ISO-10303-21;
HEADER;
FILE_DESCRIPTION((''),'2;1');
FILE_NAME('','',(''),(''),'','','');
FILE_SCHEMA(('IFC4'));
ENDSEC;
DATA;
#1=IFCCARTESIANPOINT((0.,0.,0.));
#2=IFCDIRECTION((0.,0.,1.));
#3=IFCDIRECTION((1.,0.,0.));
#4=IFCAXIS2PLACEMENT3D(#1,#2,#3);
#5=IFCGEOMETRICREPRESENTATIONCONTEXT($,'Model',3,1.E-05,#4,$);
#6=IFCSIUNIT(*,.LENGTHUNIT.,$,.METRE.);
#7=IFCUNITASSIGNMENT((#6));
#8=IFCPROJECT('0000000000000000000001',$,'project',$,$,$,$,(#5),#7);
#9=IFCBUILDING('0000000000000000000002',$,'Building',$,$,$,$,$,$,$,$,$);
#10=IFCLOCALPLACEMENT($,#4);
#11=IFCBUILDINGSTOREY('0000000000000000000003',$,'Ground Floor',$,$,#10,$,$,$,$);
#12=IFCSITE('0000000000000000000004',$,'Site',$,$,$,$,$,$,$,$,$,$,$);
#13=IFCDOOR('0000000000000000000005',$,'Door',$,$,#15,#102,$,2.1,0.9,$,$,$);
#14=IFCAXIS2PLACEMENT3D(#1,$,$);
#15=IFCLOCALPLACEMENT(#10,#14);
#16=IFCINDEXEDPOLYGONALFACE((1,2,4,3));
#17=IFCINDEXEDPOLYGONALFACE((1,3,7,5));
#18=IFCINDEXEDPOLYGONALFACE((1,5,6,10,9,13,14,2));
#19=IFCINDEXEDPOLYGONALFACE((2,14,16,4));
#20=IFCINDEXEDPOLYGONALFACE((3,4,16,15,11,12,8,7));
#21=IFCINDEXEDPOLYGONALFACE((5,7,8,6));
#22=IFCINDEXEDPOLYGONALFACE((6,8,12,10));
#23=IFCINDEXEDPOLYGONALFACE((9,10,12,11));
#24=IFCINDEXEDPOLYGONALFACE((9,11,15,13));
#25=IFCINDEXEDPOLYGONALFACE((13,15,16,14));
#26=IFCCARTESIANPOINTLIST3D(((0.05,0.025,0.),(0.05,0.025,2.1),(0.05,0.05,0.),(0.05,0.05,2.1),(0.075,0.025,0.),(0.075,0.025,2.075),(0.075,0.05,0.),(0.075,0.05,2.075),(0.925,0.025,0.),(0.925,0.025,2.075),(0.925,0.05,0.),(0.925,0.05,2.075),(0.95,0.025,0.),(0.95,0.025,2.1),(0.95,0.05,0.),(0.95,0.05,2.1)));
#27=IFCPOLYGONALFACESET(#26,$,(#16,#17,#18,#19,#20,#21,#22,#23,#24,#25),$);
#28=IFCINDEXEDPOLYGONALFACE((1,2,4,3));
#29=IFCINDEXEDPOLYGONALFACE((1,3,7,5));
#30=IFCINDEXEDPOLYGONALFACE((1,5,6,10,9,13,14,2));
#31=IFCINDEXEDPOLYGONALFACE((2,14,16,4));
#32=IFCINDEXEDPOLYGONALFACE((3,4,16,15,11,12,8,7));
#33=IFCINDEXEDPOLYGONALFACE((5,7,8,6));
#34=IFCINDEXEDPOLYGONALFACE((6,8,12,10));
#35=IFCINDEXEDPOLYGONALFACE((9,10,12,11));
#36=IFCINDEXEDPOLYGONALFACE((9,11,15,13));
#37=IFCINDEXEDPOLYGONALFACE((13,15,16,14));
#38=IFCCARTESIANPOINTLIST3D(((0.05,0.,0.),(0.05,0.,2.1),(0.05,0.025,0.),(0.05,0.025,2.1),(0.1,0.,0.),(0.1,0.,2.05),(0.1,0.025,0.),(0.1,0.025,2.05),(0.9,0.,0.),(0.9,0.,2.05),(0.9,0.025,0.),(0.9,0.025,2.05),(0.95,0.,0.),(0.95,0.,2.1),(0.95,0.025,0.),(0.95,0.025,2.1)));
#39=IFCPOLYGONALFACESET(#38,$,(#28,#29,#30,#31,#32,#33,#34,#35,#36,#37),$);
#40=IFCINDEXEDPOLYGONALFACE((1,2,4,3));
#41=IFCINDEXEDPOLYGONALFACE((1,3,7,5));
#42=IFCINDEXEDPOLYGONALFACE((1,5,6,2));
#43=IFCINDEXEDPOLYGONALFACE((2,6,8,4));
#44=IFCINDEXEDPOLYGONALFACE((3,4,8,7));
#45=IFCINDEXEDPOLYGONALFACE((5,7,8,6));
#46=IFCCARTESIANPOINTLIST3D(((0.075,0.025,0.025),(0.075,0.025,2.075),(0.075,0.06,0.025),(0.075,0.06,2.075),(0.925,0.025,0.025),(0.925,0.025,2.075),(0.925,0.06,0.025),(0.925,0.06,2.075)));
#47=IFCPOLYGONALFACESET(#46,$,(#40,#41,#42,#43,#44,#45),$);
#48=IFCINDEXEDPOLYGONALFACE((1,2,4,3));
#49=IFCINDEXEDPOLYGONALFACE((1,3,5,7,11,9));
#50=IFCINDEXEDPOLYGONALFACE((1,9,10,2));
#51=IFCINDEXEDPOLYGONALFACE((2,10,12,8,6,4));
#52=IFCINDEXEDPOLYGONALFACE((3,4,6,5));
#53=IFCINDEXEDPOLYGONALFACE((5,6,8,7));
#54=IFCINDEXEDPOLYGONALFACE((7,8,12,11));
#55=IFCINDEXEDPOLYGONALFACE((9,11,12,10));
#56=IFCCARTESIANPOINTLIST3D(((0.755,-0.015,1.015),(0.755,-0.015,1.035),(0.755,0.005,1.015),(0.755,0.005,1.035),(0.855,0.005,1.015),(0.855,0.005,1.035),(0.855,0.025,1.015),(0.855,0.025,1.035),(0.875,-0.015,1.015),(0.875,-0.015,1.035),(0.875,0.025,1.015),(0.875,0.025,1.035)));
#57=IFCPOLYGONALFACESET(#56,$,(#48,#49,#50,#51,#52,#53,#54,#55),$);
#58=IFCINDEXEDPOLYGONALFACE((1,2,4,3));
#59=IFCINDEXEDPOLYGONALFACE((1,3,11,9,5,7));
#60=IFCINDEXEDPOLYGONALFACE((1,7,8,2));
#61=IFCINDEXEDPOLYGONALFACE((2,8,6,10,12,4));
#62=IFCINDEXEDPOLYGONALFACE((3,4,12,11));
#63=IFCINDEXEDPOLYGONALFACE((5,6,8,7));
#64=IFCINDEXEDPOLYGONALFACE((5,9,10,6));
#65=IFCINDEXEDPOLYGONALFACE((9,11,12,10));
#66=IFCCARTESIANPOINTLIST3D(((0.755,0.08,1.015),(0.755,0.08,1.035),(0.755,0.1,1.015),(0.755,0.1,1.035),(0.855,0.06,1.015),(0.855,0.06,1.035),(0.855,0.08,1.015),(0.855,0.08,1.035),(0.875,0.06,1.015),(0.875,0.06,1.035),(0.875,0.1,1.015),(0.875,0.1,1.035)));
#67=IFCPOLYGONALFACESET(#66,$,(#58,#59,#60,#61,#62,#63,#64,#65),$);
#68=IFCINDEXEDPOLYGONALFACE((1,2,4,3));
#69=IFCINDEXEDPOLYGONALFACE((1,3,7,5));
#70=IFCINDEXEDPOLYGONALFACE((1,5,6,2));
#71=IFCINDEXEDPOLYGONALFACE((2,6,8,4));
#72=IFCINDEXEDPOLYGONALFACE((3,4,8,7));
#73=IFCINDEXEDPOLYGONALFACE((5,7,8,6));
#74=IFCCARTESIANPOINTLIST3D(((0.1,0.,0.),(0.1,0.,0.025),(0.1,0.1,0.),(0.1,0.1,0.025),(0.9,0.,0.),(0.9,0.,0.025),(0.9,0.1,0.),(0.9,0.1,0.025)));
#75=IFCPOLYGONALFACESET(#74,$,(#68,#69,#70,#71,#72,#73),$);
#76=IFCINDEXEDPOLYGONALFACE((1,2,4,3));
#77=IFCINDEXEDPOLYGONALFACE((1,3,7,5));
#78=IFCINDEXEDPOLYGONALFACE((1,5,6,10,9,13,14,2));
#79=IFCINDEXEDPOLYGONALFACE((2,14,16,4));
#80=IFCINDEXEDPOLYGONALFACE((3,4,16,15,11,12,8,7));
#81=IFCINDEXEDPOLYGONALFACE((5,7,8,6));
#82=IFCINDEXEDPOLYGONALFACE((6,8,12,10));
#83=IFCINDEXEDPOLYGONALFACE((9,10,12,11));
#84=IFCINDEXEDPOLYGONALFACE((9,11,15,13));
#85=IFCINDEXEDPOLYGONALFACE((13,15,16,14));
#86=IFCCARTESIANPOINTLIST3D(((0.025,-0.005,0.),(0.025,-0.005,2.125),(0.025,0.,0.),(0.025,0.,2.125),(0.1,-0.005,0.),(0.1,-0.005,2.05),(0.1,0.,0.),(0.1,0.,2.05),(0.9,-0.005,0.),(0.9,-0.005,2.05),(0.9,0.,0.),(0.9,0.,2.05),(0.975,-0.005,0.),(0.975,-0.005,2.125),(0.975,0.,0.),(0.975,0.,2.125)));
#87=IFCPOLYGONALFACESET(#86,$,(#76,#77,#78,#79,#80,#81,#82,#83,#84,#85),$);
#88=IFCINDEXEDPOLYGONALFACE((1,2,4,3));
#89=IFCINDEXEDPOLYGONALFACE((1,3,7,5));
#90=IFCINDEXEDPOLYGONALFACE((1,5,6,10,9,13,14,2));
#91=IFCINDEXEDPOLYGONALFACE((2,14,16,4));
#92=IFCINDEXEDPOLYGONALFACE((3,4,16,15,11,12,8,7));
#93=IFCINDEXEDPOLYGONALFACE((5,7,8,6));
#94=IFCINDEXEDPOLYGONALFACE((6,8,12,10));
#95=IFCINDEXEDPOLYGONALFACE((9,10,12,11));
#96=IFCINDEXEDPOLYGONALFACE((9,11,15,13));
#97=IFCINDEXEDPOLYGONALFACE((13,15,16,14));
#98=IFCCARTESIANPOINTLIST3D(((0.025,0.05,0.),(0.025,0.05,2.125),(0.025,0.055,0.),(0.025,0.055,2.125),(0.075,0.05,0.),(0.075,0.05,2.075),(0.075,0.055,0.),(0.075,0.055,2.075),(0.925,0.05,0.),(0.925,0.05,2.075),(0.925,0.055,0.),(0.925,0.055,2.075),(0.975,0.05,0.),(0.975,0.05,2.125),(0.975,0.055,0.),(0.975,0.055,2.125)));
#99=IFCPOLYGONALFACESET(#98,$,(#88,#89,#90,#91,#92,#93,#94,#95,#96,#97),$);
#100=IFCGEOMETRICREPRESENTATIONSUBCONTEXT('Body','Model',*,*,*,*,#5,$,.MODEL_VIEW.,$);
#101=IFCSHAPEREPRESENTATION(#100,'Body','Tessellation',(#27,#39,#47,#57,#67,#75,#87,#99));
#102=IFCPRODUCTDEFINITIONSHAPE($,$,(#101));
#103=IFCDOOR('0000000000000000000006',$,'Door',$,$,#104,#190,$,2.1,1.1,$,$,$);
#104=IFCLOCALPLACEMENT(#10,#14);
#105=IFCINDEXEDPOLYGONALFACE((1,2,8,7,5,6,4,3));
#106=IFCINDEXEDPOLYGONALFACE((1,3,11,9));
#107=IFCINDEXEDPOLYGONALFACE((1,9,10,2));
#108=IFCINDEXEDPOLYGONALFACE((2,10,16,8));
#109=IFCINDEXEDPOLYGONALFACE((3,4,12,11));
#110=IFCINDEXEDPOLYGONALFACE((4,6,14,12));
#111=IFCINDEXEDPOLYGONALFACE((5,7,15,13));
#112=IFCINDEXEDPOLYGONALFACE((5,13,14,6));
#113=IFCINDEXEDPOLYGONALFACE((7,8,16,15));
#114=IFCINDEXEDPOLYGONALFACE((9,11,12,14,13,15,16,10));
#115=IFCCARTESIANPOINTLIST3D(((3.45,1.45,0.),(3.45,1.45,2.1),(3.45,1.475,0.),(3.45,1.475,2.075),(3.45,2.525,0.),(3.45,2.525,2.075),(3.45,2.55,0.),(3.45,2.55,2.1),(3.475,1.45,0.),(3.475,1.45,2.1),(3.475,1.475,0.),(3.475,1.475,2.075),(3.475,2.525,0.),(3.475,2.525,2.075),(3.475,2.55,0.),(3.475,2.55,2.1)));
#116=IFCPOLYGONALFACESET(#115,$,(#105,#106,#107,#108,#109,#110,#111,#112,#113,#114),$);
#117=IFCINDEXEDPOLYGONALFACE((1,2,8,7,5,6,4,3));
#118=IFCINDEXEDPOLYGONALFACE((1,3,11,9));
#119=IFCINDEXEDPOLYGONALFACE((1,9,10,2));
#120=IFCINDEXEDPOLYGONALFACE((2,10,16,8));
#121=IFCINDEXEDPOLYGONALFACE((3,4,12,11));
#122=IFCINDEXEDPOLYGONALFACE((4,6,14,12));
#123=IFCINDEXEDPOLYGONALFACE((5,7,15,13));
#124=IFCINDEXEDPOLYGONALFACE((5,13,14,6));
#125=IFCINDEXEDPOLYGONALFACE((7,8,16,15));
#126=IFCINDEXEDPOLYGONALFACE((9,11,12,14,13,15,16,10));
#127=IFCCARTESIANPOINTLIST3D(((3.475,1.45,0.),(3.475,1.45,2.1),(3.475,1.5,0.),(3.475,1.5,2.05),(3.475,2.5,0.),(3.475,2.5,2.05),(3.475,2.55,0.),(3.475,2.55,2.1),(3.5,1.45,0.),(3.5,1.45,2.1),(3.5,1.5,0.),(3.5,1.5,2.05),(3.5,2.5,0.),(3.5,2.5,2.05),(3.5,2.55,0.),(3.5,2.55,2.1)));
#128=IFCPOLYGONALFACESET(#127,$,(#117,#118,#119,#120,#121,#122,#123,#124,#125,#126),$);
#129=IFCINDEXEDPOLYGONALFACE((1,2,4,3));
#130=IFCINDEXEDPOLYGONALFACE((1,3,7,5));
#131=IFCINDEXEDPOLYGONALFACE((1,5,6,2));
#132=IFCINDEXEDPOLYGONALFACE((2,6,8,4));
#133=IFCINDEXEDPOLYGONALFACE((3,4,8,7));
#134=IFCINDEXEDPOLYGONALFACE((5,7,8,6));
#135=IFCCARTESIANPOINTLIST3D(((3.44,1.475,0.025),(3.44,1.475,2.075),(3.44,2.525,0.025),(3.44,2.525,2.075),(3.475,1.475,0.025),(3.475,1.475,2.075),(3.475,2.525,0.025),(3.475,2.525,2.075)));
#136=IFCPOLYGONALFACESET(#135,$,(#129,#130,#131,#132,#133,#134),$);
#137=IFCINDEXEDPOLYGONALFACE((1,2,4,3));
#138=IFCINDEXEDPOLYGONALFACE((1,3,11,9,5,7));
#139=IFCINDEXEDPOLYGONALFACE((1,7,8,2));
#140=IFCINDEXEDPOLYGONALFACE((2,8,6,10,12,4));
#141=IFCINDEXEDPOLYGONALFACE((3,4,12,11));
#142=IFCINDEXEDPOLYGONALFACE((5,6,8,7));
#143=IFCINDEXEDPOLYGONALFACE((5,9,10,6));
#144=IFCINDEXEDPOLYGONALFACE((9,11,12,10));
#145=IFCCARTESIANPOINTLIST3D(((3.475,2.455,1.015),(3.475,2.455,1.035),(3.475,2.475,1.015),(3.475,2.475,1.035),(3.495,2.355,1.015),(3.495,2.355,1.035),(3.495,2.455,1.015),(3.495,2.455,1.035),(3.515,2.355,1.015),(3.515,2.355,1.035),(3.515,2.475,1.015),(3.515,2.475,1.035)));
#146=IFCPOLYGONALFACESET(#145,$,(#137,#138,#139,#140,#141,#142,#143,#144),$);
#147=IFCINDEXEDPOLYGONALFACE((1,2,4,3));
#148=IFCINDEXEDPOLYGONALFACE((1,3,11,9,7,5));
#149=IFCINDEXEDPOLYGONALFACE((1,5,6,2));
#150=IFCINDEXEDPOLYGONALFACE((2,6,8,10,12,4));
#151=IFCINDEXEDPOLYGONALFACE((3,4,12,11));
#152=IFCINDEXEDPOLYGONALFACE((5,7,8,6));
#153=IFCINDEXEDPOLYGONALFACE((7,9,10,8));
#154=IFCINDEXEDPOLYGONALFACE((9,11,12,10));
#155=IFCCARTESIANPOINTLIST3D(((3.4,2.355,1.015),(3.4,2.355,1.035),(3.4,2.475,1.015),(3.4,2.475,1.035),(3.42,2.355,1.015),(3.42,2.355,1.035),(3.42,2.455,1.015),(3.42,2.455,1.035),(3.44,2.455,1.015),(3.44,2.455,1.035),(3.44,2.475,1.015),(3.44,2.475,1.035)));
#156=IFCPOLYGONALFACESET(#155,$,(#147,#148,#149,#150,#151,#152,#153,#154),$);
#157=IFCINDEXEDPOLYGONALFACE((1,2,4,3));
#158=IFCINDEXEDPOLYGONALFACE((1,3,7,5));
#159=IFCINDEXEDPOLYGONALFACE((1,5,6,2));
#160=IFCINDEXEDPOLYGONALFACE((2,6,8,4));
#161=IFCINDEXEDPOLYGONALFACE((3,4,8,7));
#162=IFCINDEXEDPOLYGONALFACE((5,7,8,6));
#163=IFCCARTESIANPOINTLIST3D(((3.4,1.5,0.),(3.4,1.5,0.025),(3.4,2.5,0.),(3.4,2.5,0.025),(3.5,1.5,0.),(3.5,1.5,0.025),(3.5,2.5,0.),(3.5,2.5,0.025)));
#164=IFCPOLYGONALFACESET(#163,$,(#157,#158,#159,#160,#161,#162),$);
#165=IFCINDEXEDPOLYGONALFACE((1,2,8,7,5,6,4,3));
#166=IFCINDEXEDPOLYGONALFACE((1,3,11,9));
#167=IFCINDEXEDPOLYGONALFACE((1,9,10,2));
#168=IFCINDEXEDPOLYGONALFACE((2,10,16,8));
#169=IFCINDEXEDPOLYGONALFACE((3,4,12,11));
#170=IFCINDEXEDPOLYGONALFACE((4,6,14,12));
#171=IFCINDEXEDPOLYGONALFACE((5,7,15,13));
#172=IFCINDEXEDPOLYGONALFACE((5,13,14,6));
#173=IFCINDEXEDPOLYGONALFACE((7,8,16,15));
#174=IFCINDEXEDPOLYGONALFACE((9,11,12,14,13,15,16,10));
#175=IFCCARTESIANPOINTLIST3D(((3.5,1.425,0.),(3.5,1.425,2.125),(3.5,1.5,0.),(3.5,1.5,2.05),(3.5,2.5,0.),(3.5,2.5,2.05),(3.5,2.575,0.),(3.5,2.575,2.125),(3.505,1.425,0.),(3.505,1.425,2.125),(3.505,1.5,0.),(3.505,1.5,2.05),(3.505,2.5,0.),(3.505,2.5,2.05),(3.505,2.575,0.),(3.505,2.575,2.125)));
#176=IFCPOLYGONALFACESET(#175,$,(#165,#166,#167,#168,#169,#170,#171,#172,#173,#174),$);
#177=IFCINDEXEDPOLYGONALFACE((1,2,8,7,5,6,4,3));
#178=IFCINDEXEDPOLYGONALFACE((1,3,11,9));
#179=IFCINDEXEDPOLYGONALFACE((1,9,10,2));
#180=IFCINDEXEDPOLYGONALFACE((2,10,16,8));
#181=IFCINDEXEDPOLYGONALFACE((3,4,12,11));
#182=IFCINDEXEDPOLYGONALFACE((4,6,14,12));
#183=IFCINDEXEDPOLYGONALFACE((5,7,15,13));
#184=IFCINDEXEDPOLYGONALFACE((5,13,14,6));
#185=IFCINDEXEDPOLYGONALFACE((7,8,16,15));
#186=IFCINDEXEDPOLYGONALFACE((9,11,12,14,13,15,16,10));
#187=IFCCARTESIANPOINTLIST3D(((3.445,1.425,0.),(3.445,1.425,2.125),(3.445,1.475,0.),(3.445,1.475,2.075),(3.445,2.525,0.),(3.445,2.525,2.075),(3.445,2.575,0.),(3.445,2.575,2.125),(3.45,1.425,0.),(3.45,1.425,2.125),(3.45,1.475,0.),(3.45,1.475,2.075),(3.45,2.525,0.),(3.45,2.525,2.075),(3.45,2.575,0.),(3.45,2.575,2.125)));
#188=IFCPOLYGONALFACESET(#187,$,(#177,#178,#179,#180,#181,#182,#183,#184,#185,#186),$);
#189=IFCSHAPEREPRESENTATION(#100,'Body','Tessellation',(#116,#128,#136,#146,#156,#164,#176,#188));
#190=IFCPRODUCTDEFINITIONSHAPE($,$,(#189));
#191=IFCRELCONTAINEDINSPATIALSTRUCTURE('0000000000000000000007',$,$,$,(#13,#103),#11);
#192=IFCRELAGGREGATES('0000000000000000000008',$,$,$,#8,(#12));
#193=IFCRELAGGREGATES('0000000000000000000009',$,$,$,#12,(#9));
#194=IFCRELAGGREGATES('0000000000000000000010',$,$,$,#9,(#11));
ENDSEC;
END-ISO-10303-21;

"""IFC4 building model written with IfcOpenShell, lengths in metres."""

from ifc_helpers import new_model, si_unit, frame, origin_with_axes, place, context, subcontext, project, spatial, line, indexed_curve, outline, extrude, element, save


model = new_model("IFC4")

# Units and contexts
model_context = context("Model", 3, precision=1e-05, world=origin_with_axes())
body_context = subcontext(model_context, "Body", "Model", "MODEL_VIEW")
ifc_project = project(units=[si_unit("LENGTHUNIT", "METRE")], contexts=[model_context])

# Site, building, storey
site = spatial("IfcSite", under=ifc_project, Name="Site")
building = spatial("IfcBuilding", under=site, Name="Building")
storey_placement = place(None, origin_with_axes())
storey = spatial("IfcBuildingStorey", under=building, at=storey_placement, Name="Ground Floor")

# Doors
door_1_placement = place(storey_placement, frame((0.05, 0.0, 0.0), z_axis=(0.0, 0.0, 1.0), x_axis=(1.0, 0.0, 0.0)))
element("IfcDoor", 1, at=door_1_placement, inside=storey, Name="Door", OverallHeight=2.1, OverallWidth=0.9, context=body_context, shape_type="SweptSolid", body=[
    extrude(outline(indexed_curve([(0.0, 0.0), (0.0, 2.1), (0.9, 2.1), (0.9, 0.0), (0.875, 0.0), (0.875, 2.075), (0.025, 2.075), (0.025, 0.0)], segments=[line(1, 2, 3, 4, 5, 6, 7, 8, 1)])), frame((0.0, 0.025, 0.0), z_axis=(0.0, -1.0, 0.0), x_axis=(1.0, 0.0, 0.0)), (0.0, 0.0, -1.0), 0.025),
    extrude(outline(indexed_curve([(0.0, 0.0), (0.0, 2.1), (0.9, 2.1), (0.9, 0.0), (0.85, 0.0), (0.85, 2.05), (0.05, 2.05), (0.05, 0.0)], segments=[line(1, 2, 3, 4, 5, 6, 7, 8, 1)])), frame((0.0, 0.0, 0.0), z_axis=(0.0, -1.0, 0.0), x_axis=(1.0, 0.0, 0.0)), (0.0, 0.0, -1.0), 0.025),
    extrude(outline(indexed_curve([(0.0, 0.0), (0.85, 0.0), (0.85, 0.035), (0.0, 0.035)], segments=[line(1, 2, 3, 4, 1)])), frame((0.025, 0.025, 0.025), z_axis=(0.0, 0.0, 1.0), x_axis=(1.0, 0.0, 0.0)), (0.0, 0.0, 1.0), 2.05),
    extrude(outline(indexed_curve([(0.0, 0.0), (0.0, -0.04), (-0.12, -0.04), (-0.12, -0.02), (-0.02, -0.02), (-0.02, 0.0)], segments=[line(1, 2, 3, 4, 5, 6, 1)])), frame((0.825, 0.025, 1.015), z_axis=(0.0, 0.0, 1.0), x_axis=(1.0, 0.0, 0.0)), (0.0, 0.0, 1.0), 0.02),
    extrude(outline(indexed_curve([(0.0, 0.0), (0.0, 0.04), (-0.12, 0.04), (-0.12, 0.02), (-0.02, 0.02), (-0.02, 0.0)], segments=[line(1, 2, 3, 4, 5, 6, 1)])), frame((0.825, 0.06, 1.015), z_axis=(0.0, 0.0, 1.0), x_axis=(1.0, 0.0, 0.0)), (0.0, 0.0, 1.0), 0.02),
    extrude(outline(indexed_curve([(0.0, 0.0), (0.8, 0.0), (0.8, 0.1), (0.0, 0.1)], segments=[line(1, 2, 3, 4, 1)])), frame((0.05, 0.0, 0.0), z_axis=(0.0, 0.0, 1.0), x_axis=(1.0, 0.0, 0.0)), (0.0, 0.0, 1.0), 0.025),
    extrude(outline(indexed_curve([(0.0, 0.0), (0.0, 2.125), (0.95, 2.125), (0.95, 0.0), (0.875, 0.0), (0.875, 2.05), (0.075, 2.05), (0.075, 0.0)], segments=[line(1, 2, 3, 4, 5, 6, 7, 8, 1)])), frame((-0.025, -0.005, 0.0), z_axis=(0.0, -1.0, 0.0), x_axis=(1.0, 0.0, 0.0)), (0.0, 0.0, -1.0), 0.005),
    extrude(outline(indexed_curve([(0.0, 0.0), (0.0, 2.125), (0.95, 2.125), (0.95, 0.0), (0.9, 0.0), (0.9, 2.075), (0.05, 2.075), (0.05, 0.0)], segments=[line(1, 2, 3, 4, 5, 6, 7, 8, 1)])), frame((-0.025, 0.05, 0.0), z_axis=(0.0, -1.0, 0.0), x_axis=(1.0, 0.0, 0.0)), (0.0, 0.0, -1.0), 0.005),
])
door_2_placement = place(storey_placement, frame((3.5, 1.45, 0.0), z_axis=(0.0, 0.0, 1.0), x_axis=(0.0, 1.0, 0.0)))
element("IfcDoor", 2, at=door_2_placement, inside=storey, Name="Door", OverallHeight=2.1, OverallWidth=1.1, context=body_context, shape_type="SweptSolid", body=[
    extrude(outline(indexed_curve([(0.0, 0.0), (0.0, 2.1), (1.1, 2.1), (1.1, 0.0), (1.075, 0.0), (1.075, 2.075), (0.025, 2.075), (0.025, 0.0)], segments=[line(1, 2, 3, 4, 5, 6, 7, 8, 1)])), frame((0.0, 0.025, 0.0), z_axis=(0.0, -1.0, 0.0), x_axis=(1.0, 0.0, 0.0)), (0.0, 0.0, -1.0), 0.025),
    extrude(outline(indexed_curve([(0.0, 0.0), (0.0, 2.1), (1.1, 2.1), (1.1, 0.0), (1.05, 0.0), (1.05, 2.05), (0.05, 2.05), (0.05, 0.0)], segments=[line(1, 2, 3, 4, 5, 6, 7, 8, 1)])), frame((0.0, 0.0, 0.0), z_axis=(0.0, -1.0, 0.0), x_axis=(1.0, 0.0, 0.0)), (0.0, 0.0, -1.0), 0.025),
    extrude(outline(indexed_curve([(0.0, 0.0), (1.05, 0.0), (1.05, 0.035), (0.0, 0.035)], segments=[line(1, 2, 3, 4, 1)])), frame((0.025, 0.025, 0.025), z_axis=(0.0, 0.0, 1.0), x_axis=(1.0, 0.0, 0.0)), (0.0, 0.0, 1.0), 2.05),
    extrude(outline(indexed_curve([(0.0, 0.0), (0.0, -0.04), (-0.12, -0.04), (-0.12, -0.02), (-0.02, -0.02), (-0.02, 0.0)], segments=[line(1, 2, 3, 4, 5, 6, 1)])), frame((1.025, 0.025, 1.015), z_axis=(0.0, 0.0, 1.0), x_axis=(1.0, 0.0, 0.0)), (0.0, 0.0, 1.0), 0.02),
    extrude(outline(indexed_curve([(0.0, 0.0), (0.0, 0.04), (-0.12, 0.04), (-0.12, 0.02), (-0.02, 0.02), (-0.02, 0.0)], segments=[line(1, 2, 3, 4, 5, 6, 1)])), frame((1.025, 0.06, 1.015), z_axis=(0.0, 0.0, 1.0), x_axis=(1.0, 0.0, 0.0)), (0.0, 0.0, 1.0), 0.02),
    extrude(outline(indexed_curve([(0.0, 0.0), (1.0, 0.0), (1.0, 0.1), (0.0, 0.1)], segments=[line(1, 2, 3, 4, 1)])), frame((0.05, 0.0, 0.0), z_axis=(0.0, 0.0, 1.0), x_axis=(1.0, 0.0, 0.0)), (0.0, 0.0, 1.0), 0.025),
    extrude(outline(indexed_curve([(0.0, 0.0), (0.0, 2.125), (1.15, 2.125), (1.15, 0.0), (1.075, 0.0), (1.075, 2.05), (0.075, 2.05), (0.075, 0.0)], segments=[line(1, 2, 3, 4, 5, 6, 7, 8, 1)])), frame((-0.025, -0.005, 0.0), z_axis=(0.0, -1.0, 0.0), x_axis=(1.0, 0.0, 0.0)), (0.0, 0.0, -1.0), 0.005),
    extrude(outline(indexed_curve([(0.0, 0.0), (0.0, 2.125), (1.15, 2.125), (1.15, 0.0), (1.1, 0.0), (1.1, 2.075), (0.05, 2.075), (0.05, 0.0)], segments=[line(1, 2, 3, 4, 5, 6, 7, 8, 1)])), frame((-0.025, 0.05, 0.0), z_axis=(0.0, -1.0, 0.0), x_axis=(1.0, 0.0, 0.0)), (0.0, 0.0, -1.0), 0.005),
])

save(model, "model.ifc")
